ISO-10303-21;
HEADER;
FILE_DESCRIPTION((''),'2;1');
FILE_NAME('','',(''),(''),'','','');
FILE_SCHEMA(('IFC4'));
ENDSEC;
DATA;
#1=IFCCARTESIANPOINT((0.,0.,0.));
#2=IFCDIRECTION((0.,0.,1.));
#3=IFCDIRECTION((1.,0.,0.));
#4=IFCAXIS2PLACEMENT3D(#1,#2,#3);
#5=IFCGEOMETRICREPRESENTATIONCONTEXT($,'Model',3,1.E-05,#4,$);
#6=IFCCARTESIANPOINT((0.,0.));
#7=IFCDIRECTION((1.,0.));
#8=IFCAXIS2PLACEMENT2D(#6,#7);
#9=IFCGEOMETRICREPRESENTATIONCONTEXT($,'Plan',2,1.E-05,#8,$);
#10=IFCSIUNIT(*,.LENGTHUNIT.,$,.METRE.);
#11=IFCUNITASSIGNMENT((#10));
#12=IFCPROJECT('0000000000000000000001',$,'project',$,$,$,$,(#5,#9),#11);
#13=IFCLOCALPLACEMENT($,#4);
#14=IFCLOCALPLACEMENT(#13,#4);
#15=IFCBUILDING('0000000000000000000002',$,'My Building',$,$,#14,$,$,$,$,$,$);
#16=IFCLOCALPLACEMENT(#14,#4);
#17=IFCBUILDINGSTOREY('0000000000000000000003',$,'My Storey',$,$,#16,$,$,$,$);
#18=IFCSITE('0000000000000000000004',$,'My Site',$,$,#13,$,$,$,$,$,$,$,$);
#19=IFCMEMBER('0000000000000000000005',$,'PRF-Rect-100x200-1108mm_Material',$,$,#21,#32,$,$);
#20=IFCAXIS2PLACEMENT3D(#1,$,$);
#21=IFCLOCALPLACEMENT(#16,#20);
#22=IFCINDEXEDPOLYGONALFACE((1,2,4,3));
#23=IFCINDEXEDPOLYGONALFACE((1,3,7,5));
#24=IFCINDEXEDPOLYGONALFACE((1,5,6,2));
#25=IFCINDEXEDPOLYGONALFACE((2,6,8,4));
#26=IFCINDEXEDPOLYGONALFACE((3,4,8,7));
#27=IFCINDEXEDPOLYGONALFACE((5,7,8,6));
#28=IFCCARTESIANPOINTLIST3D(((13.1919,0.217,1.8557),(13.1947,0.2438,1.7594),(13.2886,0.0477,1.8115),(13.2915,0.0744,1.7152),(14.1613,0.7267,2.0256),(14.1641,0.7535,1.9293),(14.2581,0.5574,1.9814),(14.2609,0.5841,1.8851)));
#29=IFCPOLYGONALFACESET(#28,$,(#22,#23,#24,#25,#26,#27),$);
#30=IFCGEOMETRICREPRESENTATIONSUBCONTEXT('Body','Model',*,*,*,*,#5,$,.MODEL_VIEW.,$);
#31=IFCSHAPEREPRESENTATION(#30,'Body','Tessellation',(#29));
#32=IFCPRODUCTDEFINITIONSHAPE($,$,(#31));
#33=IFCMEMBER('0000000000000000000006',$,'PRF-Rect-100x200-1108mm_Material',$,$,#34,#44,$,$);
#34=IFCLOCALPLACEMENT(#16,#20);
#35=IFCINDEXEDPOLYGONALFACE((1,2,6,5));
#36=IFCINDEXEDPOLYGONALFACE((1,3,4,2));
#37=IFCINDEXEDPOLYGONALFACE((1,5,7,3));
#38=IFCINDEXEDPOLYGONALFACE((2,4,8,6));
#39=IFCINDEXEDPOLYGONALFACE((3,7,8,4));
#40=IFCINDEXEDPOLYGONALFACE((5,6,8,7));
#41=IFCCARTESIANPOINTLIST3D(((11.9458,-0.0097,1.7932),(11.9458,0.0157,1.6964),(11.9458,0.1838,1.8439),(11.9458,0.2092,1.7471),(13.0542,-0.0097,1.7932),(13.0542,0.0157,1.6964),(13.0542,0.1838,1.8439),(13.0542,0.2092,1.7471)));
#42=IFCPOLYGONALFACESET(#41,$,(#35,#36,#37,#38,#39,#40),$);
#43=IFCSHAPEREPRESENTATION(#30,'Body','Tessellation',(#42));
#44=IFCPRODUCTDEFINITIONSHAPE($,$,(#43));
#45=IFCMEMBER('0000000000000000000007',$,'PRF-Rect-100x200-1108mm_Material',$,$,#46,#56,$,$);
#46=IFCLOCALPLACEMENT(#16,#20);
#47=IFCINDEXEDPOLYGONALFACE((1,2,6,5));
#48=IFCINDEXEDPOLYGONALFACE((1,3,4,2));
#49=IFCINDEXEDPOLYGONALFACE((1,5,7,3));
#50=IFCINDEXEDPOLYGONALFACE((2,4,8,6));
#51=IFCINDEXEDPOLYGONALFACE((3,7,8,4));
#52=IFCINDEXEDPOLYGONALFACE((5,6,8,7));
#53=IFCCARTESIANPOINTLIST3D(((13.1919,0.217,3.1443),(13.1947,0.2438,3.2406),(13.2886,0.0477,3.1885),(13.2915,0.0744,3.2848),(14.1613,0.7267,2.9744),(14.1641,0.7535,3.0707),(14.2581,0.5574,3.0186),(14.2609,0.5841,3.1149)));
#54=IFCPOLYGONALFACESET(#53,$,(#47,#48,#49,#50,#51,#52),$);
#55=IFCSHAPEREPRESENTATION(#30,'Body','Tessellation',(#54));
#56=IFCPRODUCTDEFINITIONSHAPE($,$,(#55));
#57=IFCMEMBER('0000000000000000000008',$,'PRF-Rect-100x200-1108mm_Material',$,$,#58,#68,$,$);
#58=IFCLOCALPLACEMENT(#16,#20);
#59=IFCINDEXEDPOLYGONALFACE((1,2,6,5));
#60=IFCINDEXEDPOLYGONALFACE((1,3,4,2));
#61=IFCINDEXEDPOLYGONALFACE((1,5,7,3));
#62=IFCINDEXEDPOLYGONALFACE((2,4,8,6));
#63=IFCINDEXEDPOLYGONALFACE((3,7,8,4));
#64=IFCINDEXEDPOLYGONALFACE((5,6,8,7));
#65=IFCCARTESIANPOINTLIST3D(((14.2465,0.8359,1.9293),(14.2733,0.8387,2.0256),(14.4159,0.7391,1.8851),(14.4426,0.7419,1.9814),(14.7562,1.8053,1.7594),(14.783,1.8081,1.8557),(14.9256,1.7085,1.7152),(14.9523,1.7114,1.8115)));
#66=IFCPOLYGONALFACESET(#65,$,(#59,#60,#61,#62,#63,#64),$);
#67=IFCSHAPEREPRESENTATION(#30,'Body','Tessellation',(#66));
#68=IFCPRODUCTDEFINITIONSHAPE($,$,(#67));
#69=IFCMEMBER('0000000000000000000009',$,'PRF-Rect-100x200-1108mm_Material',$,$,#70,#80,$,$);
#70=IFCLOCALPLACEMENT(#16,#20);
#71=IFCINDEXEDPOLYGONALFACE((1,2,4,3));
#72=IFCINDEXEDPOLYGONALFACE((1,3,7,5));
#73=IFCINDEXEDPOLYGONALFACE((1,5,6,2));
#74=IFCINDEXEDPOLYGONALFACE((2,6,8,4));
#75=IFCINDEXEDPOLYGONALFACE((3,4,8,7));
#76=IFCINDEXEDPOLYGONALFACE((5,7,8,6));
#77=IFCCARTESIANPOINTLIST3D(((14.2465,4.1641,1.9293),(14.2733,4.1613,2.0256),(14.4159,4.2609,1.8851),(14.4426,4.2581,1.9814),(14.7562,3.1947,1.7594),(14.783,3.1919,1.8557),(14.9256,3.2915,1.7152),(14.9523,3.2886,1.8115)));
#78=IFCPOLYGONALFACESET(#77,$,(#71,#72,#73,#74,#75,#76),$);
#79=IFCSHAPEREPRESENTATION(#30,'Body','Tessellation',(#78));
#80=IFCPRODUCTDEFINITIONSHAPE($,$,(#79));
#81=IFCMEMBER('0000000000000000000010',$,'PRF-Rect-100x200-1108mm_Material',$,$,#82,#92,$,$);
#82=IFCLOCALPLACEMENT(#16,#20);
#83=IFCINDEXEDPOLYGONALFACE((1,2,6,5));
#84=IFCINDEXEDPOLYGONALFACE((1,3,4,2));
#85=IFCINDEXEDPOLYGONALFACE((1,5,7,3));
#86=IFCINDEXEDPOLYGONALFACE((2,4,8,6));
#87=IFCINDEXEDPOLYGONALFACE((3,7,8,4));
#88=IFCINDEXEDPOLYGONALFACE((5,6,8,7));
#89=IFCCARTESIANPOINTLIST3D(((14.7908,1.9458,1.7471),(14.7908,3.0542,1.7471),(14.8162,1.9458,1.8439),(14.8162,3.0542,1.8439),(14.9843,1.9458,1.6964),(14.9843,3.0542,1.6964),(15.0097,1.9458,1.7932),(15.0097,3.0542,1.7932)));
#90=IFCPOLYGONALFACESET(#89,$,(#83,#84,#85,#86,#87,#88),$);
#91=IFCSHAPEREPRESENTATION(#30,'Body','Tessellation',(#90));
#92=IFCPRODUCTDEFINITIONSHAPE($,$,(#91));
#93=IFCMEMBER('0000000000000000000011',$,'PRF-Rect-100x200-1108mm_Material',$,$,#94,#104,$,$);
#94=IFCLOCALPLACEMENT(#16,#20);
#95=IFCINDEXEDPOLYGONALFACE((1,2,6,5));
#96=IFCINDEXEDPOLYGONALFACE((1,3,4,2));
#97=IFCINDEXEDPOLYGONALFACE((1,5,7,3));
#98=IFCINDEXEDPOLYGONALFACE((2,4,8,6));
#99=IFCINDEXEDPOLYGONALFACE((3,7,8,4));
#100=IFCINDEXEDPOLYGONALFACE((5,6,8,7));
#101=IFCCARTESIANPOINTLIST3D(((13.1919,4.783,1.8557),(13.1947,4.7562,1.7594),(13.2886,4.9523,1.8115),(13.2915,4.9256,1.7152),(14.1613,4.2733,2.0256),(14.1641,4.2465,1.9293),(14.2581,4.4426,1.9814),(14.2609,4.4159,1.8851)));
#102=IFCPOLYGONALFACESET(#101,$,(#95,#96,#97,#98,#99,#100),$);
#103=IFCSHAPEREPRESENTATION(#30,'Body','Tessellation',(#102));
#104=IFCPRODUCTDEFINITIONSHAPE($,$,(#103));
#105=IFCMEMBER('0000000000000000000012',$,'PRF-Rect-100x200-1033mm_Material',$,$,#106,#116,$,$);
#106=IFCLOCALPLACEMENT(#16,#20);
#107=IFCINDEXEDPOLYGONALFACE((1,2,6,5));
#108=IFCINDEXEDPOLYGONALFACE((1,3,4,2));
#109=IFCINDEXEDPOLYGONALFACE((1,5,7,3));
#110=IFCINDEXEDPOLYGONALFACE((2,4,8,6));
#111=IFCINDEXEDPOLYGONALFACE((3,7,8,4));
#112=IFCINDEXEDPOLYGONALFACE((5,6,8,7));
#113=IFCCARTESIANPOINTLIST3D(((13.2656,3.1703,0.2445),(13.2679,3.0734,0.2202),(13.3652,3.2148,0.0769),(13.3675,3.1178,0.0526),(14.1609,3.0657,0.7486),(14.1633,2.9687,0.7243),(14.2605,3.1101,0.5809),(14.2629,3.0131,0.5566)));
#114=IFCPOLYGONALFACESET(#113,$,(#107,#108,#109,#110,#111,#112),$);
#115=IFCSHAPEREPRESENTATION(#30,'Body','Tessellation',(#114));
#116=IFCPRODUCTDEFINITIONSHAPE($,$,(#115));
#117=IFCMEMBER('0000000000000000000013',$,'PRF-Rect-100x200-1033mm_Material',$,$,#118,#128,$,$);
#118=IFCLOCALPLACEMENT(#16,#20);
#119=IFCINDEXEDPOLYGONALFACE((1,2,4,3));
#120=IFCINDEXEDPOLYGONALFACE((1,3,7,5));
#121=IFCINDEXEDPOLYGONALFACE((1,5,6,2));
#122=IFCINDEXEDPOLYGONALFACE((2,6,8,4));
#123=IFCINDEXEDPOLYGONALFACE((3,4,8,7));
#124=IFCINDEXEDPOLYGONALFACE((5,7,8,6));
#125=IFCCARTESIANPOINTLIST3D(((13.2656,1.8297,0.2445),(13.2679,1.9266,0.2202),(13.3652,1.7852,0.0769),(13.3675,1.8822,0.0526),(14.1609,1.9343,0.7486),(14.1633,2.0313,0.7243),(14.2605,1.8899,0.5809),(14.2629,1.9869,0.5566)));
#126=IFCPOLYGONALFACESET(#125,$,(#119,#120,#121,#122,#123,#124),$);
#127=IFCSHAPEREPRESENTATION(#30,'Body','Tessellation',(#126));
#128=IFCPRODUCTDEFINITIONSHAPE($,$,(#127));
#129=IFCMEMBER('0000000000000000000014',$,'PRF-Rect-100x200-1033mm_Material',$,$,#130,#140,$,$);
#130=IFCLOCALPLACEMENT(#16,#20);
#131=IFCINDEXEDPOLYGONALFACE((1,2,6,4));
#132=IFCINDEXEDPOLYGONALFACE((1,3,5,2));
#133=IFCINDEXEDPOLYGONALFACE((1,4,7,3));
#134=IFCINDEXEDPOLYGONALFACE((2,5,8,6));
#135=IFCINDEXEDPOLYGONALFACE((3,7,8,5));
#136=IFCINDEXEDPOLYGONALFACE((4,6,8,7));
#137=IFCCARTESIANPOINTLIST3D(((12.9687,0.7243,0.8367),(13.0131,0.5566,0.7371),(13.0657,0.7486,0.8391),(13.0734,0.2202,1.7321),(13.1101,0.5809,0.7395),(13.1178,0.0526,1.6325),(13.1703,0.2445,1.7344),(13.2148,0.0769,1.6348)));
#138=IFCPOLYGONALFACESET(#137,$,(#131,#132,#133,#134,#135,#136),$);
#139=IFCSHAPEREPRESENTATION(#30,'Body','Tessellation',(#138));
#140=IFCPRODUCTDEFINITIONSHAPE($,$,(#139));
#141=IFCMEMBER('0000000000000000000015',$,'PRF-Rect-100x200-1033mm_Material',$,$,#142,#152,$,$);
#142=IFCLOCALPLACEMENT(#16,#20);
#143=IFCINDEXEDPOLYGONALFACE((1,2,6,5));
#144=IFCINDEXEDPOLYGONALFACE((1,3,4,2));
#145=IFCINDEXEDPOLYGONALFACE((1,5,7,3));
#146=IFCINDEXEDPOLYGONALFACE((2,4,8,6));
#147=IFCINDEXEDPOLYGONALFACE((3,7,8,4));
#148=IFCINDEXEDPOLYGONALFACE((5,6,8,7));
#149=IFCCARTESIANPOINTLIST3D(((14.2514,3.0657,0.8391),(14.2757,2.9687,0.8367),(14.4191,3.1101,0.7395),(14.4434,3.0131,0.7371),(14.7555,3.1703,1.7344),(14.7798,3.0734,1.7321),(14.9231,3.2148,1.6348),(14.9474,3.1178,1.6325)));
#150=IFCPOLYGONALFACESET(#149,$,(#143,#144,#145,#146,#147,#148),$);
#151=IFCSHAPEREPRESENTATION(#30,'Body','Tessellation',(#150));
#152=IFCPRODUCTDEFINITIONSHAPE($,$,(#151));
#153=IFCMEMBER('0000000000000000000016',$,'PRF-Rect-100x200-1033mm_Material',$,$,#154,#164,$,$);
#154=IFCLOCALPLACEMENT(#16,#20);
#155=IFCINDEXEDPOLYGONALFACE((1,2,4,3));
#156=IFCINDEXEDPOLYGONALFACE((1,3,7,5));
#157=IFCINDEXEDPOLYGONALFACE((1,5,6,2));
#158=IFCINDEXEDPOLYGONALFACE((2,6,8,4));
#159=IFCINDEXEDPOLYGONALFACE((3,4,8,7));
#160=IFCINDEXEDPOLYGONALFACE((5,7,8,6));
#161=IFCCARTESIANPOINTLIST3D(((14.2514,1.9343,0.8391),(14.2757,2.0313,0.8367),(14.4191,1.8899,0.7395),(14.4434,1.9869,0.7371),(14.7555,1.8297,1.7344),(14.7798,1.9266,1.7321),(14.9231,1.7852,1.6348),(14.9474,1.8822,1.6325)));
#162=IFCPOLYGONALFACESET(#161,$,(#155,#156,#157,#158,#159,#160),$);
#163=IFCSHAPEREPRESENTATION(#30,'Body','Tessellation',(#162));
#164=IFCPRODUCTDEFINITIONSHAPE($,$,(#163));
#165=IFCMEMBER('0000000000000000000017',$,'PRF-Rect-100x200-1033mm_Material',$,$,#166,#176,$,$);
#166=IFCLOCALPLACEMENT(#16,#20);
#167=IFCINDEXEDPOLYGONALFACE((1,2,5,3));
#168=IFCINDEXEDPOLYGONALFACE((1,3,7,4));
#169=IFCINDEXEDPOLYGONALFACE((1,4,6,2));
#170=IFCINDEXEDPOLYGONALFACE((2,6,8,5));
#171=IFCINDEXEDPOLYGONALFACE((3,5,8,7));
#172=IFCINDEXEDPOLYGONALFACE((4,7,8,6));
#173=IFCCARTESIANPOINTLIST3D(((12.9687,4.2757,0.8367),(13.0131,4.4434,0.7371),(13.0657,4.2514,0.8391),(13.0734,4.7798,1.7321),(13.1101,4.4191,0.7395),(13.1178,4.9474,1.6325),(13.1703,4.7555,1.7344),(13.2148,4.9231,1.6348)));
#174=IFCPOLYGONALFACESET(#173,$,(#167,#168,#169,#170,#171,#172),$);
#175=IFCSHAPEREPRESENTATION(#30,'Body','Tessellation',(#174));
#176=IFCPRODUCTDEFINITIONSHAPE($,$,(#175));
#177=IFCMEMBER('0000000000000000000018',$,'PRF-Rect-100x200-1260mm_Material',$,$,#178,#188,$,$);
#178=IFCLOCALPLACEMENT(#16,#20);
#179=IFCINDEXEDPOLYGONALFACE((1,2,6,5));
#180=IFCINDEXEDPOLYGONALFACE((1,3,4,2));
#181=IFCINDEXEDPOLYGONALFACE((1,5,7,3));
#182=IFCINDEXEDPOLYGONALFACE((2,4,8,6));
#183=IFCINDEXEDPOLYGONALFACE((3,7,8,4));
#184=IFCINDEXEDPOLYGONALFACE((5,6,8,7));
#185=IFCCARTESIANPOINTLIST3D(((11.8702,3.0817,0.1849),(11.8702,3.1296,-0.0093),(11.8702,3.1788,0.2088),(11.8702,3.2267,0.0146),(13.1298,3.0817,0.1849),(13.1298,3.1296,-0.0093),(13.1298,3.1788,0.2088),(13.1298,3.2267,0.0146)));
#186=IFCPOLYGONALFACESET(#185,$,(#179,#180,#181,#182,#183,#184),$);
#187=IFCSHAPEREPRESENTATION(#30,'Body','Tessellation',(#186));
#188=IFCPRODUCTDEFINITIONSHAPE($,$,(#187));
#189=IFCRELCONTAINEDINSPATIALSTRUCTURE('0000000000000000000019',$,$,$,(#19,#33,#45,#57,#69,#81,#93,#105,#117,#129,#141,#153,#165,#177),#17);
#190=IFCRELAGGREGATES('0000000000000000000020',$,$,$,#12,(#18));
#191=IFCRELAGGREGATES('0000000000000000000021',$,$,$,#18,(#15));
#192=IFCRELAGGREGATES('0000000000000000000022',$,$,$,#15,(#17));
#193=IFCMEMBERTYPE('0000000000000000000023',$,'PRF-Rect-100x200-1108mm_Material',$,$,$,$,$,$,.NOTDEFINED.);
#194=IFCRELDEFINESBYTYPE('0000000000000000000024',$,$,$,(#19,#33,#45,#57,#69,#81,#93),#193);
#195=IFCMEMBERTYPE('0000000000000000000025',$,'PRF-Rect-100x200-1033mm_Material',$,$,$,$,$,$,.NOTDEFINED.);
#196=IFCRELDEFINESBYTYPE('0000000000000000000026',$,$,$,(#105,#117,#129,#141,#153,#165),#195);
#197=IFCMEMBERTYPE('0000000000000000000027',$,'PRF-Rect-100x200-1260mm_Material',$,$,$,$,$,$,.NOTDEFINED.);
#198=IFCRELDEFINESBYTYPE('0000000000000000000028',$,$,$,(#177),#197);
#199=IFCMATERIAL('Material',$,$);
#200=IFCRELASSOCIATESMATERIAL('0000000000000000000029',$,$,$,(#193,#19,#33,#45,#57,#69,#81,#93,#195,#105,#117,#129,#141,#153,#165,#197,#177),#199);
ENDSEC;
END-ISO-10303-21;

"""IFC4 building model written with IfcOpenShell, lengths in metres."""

from ifc_helpers import new_model, si_unit, frame, origin, origin_with_axes, origin_2d_with_axis, place, context, subcontext, project, spatial, rectangle, extrude, material, material_profile, profile_set, profile_usage, type_object, element, save


model = new_model("IFC4")

# Units and contexts
model_context = context("Model", 3, precision=1e-05, world=origin_with_axes())
plan_context = context("Plan", 2, precision=1e-05, world=origin_2d_with_axis())
body_context = subcontext(model_context, "Body", "Model", "MODEL_VIEW")
ifc_project = project(units=[si_unit("LENGTHUNIT", "METRE")], contexts=[model_context, plan_context])

# Site, building, storey
site_placement = place(None, origin_with_axes())
site = spatial("IfcSite", under=ifc_project, at=site_placement, Name="My Site")
building_placement = place(site_placement, origin_with_axes())
building = spatial("IfcBuilding", under=site, at=building_placement, Name="My Building")
storey_placement = place(building_placement, origin_with_axes())
storey = spatial("IfcBuildingStorey", under=building, at=storey_placement, Name="My Storey")

# Members
ifc_material = material(Name="Material")
ifc_material_profile_1 = material_profile(ifc_material, rectangle(XDim=0.1, YDim=0.2))
ifc_profile_set_1 = profile_set([ifc_material_profile_1], Name="PRF-Rect-100x200-1108mm_Material")
member_type_1 = type_object("IfcMemberType", Name="PRF-Rect-100x200-1108mm_Material", PredefinedType="NOTDEFINED", material=ifc_profile_set_1)
ifc_profile_usage_1 = profile_usage(ifc_profile_set_1, cardinal=5)
member_1_placement = place(storey_placement, frame((14.2111, 0.6554, 1.9554), z_axis=(-0.874668, -0.459849, -0.153283), x_axis=(0.028153, 0.2675, -0.963147)))
element("IfcMember", 1, at=member_1_placement, inside=storey, type_object=member_type_1, material=ifc_profile_usage_1, Name="PRF-Rect-100x200-1108mm_Material", context=body_context, shape_type="SweptSolid", body=[
    extrude(rectangle(XDim=0.1, YDim=0.2), origin(), (0.0, 0.0, 1.0), 1.1084),
])
ifc_profile_usage_2 = profile_usage(ifc_profile_set_1, cardinal=5)
member_2_placement = place(storey_placement, frame((13.0542, 0.0998, 1.7702), z_axis=(-1.0, -0.000001, 0.0), x_axis=(0.0, 0.253569, -0.967317)))
element("IfcMember", 2, at=member_2_placement, inside=storey, type_object=member_type_1, material=ifc_profile_usage_2, Name="PRF-Rect-100x200-1108mm_Material", context=body_context, shape_type="SweptSolid", body=[
    extrude(rectangle(XDim=0.1, YDim=0.2), origin(), (0.0, 0.0, 1.0), 1.1084),
])
ifc_profile_usage_3 = profile_usage(ifc_profile_set_1, cardinal=5)
member_3_placement = place(storey_placement, frame((14.2111, 0.6554, 3.0446), z_axis=(-0.874667, -0.459849, 0.153283), x_axis=(-0.028153, -0.2675, -0.963147)))
element("IfcMember", 3, at=member_3_placement, inside=storey, type_object=member_type_1, material=ifc_profile_usage_3, Name="PRF-Rect-100x200-1108mm_Material", context=body_context, shape_type="SweptSolid", body=[
    extrude(rectangle(XDim=0.1, YDim=0.2), origin(), (0.0, 0.0, 1.0), 1.1084),
])
ifc_profile_usage_4 = profile_usage(ifc_profile_set_1, cardinal=5)
member_4_placement = place(storey_placement, frame((14.8543, 1.7583, 1.7855), z_axis=(-0.459849, -0.874668, 0.153283), x_axis=(-0.2675, -0.028153, -0.963147)))
element("IfcMember", 4, at=member_4_placement, inside=storey, type_object=member_type_1, material=ifc_profile_usage_4, Name="PRF-Rect-100x200-1108mm_Material", context=body_context, shape_type="SweptSolid", body=[
    extrude(rectangle(XDim=0.1, YDim=0.2), origin(), (0.0, 0.0, 1.0), 1.1084),
])
ifc_profile_usage_5 = profile_usage(ifc_profile_set_1, cardinal=5)
member_5_placement = place(storey_placement, frame((14.3446, 4.2111, 1.9554), z_axis=(0.459849, -0.874667, -0.153283), x_axis=(-0.2675, 0.028153, -0.963147)))
element("IfcMember", 5, at=member_5_placement, inside=storey, type_object=member_type_1, material=ifc_profile_usage_5, Name="PRF-Rect-100x200-1108mm_Material", context=body_context, shape_type="SweptSolid", body=[
    extrude(rectangle(XDim=0.1, YDim=0.2), origin(), (0.0, 0.0, 1.0), 1.1084),
])
ifc_profile_usage_6 = profile_usage(ifc_profile_set_1, cardinal=5)
member_6_placement = place(storey_placement, frame((14.9002, 3.0542, 1.7702), z_axis=(0.0, -1.0, 0.0), x_axis=(-0.253569, 0.0, -0.967317)))
element("IfcMember", 6, at=member_6_placement, inside=storey, type_object=member_type_1, material=ifc_profile_usage_6, Name="PRF-Rect-100x200-1108mm_Material", context=body_context, shape_type="SweptSolid", body=[
    extrude(rectangle(XDim=0.1, YDim=0.2), origin(), (0.0, 0.0, 1.0), 1.1084),
])
ifc_profile_usage_7 = profile_usage(ifc_profile_set_1, cardinal=5)
member_7_placement = place(storey_placement, frame((13.2417, 4.8543, 1.7855), z_axis=(0.874667, -0.459849, 0.153283), x_axis=(0.028153, -0.2675, -0.963147)))
element("IfcMember", 7, at=member_7_placement, inside=storey, type_object=member_type_1, material=ifc_profile_usage_7, Name="PRF-Rect-100x200-1108mm_Material", context=body_context, shape_type="SweptSolid", body=[
    extrude(rectangle(XDim=0.1, YDim=0.2), origin(), (0.0, 0.0, 1.0), 1.1084),
])
ifc_material_profile_2 = material_profile(ifc_material, rectangle(XDim=0.1, YDim=0.2))
ifc_profile_set_2 = profile_set([ifc_material_profile_2], Name="PRF-Rect-100x200-1033mm_Material")
ifc_profile_usage_8 = profile_usage(ifc_profile_set_2, cardinal=5)
member_type_2 = type_object("IfcMemberType", Name="PRF-Rect-100x200-1033mm_Material", PredefinedType="NOTDEFINED", material=ifc_profile_set_2)
member_8_placement = place(storey_placement, frame((14.2119, 3.0394, 0.6526), z_axis=(-0.866922, 0.101314, -0.488039), x_axis=(-0.023455, 0.969748, 0.242978)))
element("IfcMember", 8, at=member_8_placement, inside=storey, type_object=member_type_2, material=ifc_profile_usage_8, Name="PRF-Rect-100x200-1033mm_Material", context=body_context, shape_type="SweptSolid", body=[
    extrude(rectangle(XDim=0.1, YDim=0.2), origin(), (0.0, 0.0, 1.0), 1.0328),
])
ifc_profile_usage_9 = profile_usage(ifc_profile_set_2, cardinal=5)
member_9_placement = place(storey_placement, frame((14.2119, 1.9606, 0.6526), z_axis=(-0.866922, -0.101315, -0.488039), x_axis=(0.023454, 0.969748, -0.242978)))
element("IfcMember", 9, at=member_9_placement, inside=storey, type_object=member_type_2, material=ifc_profile_usage_9, Name="PRF-Rect-100x200-1033mm_Material", context=body_context, shape_type="SweptSolid", body=[
    extrude(rectangle(XDim=0.1, YDim=0.2), origin(), (0.0, 0.0, 1.0), 1.0328),
])
ifc_profile_usage_10 = profile_usage(ifc_profile_set_2, cardinal=5)
member_10_placement = place(storey_placement, frame((13.1441, 0.1486, 1.6835), z_axis=(-0.101314, 0.488039, -0.866922), x_axis=(0.969748, 0.242978, 0.023455)))
element("IfcMember", 10, at=member_10_placement, inside=storey, type_object=member_type_2, material=ifc_profile_usage_10, Name="PRF-Rect-100x200-1033mm_Material", context=body_context, shape_type="SweptSolid", body=[
    extrude(rectangle(XDim=0.1, YDim=0.2), origin(), (0.0, 0.0, 1.0), 1.0328),
])
ifc_profile_usage_11 = profile_usage(ifc_profile_set_2, cardinal=5)
member_11_placement = place(storey_placement, frame((14.8514, 3.1441, 1.6835), z_axis=(-0.488039, -0.101314, -0.866922), x_axis=(-0.242978, 0.969748, 0.023455)))
element("IfcMember", 11, at=member_11_placement, inside=storey, type_object=member_type_2, material=ifc_profile_usage_11, Name="PRF-Rect-100x200-1033mm_Material", context=body_context, shape_type="SweptSolid", body=[
    extrude(rectangle(XDim=0.1, YDim=0.2), origin(), (0.0, 0.0, 1.0), 1.0328),
])
ifc_profile_usage_12 = profile_usage(ifc_profile_set_2, cardinal=5)
member_12_placement = place(storey_placement, frame((14.8514, 1.8559, 1.6835), z_axis=(-0.488039, 0.101315, -0.866922), x_axis=(0.242978, 0.969748, -0.023454)))
element("IfcMember", 12, at=member_12_placement, inside=storey, type_object=member_type_2, material=ifc_profile_usage_12, Name="PRF-Rect-100x200-1033mm_Material", context=body_context, shape_type="SweptSolid", body=[
    extrude(rectangle(XDim=0.1, YDim=0.2), origin(), (0.0, 0.0, 1.0), 1.0328),
])
ifc_profile_usage_13 = profile_usage(ifc_profile_set_2, cardinal=5)
member_13_placement = place(storey_placement, frame((13.1441, 4.8514, 1.6835), z_axis=(-0.101315, -0.488039, -0.866922), x_axis=(-0.969748, 0.242978, -0.023454)))
element("IfcMember", 13, at=member_13_placement, inside=storey, type_object=member_type_2, material=ifc_profile_usage_13, Name="PRF-Rect-100x200-1033mm_Material", context=body_context, shape_type="SweptSolid", body=[
    extrude(rectangle(XDim=0.1, YDim=0.2), origin(), (0.0, 0.0, 1.0), 1.0328),
])
ifc_material_profile_3 = material_profile(ifc_material, rectangle(XDim=0.1, YDim=0.2))
ifc_profile_set_3 = profile_set([ifc_material_profile_3], Name="PRF-Rect-100x200-1260mm_Material")
ifc_profile_usage_14 = profile_usage(ifc_profile_set_3, cardinal=5)
member_type_3 = type_object("IfcMemberType", Name="PRF-Rect-100x200-1260mm_Material", PredefinedType="NOTDEFINED", material=ifc_profile_set_3)
member_14_placement = place(storey_placement, frame((13.1298, 3.1542, 0.0998), z_axis=(-1.0, 0.0, 0.0), x_axis=(0.0, 0.970857, 0.239658)))
element("IfcMember", 14, at=member_14_placement, inside=storey, type_object=member_type_3, material=ifc_profile_usage_14, Name="PRF-Rect-100x200-1260mm_Material", context=body_context, shape_type="SweptSolid", body=[
    extrude(rectangle(XDim=0.1, YDim=0.2), origin(), (0.0, 0.0, 1.0), 1.2597),
])

save(model, "model.ifc")
